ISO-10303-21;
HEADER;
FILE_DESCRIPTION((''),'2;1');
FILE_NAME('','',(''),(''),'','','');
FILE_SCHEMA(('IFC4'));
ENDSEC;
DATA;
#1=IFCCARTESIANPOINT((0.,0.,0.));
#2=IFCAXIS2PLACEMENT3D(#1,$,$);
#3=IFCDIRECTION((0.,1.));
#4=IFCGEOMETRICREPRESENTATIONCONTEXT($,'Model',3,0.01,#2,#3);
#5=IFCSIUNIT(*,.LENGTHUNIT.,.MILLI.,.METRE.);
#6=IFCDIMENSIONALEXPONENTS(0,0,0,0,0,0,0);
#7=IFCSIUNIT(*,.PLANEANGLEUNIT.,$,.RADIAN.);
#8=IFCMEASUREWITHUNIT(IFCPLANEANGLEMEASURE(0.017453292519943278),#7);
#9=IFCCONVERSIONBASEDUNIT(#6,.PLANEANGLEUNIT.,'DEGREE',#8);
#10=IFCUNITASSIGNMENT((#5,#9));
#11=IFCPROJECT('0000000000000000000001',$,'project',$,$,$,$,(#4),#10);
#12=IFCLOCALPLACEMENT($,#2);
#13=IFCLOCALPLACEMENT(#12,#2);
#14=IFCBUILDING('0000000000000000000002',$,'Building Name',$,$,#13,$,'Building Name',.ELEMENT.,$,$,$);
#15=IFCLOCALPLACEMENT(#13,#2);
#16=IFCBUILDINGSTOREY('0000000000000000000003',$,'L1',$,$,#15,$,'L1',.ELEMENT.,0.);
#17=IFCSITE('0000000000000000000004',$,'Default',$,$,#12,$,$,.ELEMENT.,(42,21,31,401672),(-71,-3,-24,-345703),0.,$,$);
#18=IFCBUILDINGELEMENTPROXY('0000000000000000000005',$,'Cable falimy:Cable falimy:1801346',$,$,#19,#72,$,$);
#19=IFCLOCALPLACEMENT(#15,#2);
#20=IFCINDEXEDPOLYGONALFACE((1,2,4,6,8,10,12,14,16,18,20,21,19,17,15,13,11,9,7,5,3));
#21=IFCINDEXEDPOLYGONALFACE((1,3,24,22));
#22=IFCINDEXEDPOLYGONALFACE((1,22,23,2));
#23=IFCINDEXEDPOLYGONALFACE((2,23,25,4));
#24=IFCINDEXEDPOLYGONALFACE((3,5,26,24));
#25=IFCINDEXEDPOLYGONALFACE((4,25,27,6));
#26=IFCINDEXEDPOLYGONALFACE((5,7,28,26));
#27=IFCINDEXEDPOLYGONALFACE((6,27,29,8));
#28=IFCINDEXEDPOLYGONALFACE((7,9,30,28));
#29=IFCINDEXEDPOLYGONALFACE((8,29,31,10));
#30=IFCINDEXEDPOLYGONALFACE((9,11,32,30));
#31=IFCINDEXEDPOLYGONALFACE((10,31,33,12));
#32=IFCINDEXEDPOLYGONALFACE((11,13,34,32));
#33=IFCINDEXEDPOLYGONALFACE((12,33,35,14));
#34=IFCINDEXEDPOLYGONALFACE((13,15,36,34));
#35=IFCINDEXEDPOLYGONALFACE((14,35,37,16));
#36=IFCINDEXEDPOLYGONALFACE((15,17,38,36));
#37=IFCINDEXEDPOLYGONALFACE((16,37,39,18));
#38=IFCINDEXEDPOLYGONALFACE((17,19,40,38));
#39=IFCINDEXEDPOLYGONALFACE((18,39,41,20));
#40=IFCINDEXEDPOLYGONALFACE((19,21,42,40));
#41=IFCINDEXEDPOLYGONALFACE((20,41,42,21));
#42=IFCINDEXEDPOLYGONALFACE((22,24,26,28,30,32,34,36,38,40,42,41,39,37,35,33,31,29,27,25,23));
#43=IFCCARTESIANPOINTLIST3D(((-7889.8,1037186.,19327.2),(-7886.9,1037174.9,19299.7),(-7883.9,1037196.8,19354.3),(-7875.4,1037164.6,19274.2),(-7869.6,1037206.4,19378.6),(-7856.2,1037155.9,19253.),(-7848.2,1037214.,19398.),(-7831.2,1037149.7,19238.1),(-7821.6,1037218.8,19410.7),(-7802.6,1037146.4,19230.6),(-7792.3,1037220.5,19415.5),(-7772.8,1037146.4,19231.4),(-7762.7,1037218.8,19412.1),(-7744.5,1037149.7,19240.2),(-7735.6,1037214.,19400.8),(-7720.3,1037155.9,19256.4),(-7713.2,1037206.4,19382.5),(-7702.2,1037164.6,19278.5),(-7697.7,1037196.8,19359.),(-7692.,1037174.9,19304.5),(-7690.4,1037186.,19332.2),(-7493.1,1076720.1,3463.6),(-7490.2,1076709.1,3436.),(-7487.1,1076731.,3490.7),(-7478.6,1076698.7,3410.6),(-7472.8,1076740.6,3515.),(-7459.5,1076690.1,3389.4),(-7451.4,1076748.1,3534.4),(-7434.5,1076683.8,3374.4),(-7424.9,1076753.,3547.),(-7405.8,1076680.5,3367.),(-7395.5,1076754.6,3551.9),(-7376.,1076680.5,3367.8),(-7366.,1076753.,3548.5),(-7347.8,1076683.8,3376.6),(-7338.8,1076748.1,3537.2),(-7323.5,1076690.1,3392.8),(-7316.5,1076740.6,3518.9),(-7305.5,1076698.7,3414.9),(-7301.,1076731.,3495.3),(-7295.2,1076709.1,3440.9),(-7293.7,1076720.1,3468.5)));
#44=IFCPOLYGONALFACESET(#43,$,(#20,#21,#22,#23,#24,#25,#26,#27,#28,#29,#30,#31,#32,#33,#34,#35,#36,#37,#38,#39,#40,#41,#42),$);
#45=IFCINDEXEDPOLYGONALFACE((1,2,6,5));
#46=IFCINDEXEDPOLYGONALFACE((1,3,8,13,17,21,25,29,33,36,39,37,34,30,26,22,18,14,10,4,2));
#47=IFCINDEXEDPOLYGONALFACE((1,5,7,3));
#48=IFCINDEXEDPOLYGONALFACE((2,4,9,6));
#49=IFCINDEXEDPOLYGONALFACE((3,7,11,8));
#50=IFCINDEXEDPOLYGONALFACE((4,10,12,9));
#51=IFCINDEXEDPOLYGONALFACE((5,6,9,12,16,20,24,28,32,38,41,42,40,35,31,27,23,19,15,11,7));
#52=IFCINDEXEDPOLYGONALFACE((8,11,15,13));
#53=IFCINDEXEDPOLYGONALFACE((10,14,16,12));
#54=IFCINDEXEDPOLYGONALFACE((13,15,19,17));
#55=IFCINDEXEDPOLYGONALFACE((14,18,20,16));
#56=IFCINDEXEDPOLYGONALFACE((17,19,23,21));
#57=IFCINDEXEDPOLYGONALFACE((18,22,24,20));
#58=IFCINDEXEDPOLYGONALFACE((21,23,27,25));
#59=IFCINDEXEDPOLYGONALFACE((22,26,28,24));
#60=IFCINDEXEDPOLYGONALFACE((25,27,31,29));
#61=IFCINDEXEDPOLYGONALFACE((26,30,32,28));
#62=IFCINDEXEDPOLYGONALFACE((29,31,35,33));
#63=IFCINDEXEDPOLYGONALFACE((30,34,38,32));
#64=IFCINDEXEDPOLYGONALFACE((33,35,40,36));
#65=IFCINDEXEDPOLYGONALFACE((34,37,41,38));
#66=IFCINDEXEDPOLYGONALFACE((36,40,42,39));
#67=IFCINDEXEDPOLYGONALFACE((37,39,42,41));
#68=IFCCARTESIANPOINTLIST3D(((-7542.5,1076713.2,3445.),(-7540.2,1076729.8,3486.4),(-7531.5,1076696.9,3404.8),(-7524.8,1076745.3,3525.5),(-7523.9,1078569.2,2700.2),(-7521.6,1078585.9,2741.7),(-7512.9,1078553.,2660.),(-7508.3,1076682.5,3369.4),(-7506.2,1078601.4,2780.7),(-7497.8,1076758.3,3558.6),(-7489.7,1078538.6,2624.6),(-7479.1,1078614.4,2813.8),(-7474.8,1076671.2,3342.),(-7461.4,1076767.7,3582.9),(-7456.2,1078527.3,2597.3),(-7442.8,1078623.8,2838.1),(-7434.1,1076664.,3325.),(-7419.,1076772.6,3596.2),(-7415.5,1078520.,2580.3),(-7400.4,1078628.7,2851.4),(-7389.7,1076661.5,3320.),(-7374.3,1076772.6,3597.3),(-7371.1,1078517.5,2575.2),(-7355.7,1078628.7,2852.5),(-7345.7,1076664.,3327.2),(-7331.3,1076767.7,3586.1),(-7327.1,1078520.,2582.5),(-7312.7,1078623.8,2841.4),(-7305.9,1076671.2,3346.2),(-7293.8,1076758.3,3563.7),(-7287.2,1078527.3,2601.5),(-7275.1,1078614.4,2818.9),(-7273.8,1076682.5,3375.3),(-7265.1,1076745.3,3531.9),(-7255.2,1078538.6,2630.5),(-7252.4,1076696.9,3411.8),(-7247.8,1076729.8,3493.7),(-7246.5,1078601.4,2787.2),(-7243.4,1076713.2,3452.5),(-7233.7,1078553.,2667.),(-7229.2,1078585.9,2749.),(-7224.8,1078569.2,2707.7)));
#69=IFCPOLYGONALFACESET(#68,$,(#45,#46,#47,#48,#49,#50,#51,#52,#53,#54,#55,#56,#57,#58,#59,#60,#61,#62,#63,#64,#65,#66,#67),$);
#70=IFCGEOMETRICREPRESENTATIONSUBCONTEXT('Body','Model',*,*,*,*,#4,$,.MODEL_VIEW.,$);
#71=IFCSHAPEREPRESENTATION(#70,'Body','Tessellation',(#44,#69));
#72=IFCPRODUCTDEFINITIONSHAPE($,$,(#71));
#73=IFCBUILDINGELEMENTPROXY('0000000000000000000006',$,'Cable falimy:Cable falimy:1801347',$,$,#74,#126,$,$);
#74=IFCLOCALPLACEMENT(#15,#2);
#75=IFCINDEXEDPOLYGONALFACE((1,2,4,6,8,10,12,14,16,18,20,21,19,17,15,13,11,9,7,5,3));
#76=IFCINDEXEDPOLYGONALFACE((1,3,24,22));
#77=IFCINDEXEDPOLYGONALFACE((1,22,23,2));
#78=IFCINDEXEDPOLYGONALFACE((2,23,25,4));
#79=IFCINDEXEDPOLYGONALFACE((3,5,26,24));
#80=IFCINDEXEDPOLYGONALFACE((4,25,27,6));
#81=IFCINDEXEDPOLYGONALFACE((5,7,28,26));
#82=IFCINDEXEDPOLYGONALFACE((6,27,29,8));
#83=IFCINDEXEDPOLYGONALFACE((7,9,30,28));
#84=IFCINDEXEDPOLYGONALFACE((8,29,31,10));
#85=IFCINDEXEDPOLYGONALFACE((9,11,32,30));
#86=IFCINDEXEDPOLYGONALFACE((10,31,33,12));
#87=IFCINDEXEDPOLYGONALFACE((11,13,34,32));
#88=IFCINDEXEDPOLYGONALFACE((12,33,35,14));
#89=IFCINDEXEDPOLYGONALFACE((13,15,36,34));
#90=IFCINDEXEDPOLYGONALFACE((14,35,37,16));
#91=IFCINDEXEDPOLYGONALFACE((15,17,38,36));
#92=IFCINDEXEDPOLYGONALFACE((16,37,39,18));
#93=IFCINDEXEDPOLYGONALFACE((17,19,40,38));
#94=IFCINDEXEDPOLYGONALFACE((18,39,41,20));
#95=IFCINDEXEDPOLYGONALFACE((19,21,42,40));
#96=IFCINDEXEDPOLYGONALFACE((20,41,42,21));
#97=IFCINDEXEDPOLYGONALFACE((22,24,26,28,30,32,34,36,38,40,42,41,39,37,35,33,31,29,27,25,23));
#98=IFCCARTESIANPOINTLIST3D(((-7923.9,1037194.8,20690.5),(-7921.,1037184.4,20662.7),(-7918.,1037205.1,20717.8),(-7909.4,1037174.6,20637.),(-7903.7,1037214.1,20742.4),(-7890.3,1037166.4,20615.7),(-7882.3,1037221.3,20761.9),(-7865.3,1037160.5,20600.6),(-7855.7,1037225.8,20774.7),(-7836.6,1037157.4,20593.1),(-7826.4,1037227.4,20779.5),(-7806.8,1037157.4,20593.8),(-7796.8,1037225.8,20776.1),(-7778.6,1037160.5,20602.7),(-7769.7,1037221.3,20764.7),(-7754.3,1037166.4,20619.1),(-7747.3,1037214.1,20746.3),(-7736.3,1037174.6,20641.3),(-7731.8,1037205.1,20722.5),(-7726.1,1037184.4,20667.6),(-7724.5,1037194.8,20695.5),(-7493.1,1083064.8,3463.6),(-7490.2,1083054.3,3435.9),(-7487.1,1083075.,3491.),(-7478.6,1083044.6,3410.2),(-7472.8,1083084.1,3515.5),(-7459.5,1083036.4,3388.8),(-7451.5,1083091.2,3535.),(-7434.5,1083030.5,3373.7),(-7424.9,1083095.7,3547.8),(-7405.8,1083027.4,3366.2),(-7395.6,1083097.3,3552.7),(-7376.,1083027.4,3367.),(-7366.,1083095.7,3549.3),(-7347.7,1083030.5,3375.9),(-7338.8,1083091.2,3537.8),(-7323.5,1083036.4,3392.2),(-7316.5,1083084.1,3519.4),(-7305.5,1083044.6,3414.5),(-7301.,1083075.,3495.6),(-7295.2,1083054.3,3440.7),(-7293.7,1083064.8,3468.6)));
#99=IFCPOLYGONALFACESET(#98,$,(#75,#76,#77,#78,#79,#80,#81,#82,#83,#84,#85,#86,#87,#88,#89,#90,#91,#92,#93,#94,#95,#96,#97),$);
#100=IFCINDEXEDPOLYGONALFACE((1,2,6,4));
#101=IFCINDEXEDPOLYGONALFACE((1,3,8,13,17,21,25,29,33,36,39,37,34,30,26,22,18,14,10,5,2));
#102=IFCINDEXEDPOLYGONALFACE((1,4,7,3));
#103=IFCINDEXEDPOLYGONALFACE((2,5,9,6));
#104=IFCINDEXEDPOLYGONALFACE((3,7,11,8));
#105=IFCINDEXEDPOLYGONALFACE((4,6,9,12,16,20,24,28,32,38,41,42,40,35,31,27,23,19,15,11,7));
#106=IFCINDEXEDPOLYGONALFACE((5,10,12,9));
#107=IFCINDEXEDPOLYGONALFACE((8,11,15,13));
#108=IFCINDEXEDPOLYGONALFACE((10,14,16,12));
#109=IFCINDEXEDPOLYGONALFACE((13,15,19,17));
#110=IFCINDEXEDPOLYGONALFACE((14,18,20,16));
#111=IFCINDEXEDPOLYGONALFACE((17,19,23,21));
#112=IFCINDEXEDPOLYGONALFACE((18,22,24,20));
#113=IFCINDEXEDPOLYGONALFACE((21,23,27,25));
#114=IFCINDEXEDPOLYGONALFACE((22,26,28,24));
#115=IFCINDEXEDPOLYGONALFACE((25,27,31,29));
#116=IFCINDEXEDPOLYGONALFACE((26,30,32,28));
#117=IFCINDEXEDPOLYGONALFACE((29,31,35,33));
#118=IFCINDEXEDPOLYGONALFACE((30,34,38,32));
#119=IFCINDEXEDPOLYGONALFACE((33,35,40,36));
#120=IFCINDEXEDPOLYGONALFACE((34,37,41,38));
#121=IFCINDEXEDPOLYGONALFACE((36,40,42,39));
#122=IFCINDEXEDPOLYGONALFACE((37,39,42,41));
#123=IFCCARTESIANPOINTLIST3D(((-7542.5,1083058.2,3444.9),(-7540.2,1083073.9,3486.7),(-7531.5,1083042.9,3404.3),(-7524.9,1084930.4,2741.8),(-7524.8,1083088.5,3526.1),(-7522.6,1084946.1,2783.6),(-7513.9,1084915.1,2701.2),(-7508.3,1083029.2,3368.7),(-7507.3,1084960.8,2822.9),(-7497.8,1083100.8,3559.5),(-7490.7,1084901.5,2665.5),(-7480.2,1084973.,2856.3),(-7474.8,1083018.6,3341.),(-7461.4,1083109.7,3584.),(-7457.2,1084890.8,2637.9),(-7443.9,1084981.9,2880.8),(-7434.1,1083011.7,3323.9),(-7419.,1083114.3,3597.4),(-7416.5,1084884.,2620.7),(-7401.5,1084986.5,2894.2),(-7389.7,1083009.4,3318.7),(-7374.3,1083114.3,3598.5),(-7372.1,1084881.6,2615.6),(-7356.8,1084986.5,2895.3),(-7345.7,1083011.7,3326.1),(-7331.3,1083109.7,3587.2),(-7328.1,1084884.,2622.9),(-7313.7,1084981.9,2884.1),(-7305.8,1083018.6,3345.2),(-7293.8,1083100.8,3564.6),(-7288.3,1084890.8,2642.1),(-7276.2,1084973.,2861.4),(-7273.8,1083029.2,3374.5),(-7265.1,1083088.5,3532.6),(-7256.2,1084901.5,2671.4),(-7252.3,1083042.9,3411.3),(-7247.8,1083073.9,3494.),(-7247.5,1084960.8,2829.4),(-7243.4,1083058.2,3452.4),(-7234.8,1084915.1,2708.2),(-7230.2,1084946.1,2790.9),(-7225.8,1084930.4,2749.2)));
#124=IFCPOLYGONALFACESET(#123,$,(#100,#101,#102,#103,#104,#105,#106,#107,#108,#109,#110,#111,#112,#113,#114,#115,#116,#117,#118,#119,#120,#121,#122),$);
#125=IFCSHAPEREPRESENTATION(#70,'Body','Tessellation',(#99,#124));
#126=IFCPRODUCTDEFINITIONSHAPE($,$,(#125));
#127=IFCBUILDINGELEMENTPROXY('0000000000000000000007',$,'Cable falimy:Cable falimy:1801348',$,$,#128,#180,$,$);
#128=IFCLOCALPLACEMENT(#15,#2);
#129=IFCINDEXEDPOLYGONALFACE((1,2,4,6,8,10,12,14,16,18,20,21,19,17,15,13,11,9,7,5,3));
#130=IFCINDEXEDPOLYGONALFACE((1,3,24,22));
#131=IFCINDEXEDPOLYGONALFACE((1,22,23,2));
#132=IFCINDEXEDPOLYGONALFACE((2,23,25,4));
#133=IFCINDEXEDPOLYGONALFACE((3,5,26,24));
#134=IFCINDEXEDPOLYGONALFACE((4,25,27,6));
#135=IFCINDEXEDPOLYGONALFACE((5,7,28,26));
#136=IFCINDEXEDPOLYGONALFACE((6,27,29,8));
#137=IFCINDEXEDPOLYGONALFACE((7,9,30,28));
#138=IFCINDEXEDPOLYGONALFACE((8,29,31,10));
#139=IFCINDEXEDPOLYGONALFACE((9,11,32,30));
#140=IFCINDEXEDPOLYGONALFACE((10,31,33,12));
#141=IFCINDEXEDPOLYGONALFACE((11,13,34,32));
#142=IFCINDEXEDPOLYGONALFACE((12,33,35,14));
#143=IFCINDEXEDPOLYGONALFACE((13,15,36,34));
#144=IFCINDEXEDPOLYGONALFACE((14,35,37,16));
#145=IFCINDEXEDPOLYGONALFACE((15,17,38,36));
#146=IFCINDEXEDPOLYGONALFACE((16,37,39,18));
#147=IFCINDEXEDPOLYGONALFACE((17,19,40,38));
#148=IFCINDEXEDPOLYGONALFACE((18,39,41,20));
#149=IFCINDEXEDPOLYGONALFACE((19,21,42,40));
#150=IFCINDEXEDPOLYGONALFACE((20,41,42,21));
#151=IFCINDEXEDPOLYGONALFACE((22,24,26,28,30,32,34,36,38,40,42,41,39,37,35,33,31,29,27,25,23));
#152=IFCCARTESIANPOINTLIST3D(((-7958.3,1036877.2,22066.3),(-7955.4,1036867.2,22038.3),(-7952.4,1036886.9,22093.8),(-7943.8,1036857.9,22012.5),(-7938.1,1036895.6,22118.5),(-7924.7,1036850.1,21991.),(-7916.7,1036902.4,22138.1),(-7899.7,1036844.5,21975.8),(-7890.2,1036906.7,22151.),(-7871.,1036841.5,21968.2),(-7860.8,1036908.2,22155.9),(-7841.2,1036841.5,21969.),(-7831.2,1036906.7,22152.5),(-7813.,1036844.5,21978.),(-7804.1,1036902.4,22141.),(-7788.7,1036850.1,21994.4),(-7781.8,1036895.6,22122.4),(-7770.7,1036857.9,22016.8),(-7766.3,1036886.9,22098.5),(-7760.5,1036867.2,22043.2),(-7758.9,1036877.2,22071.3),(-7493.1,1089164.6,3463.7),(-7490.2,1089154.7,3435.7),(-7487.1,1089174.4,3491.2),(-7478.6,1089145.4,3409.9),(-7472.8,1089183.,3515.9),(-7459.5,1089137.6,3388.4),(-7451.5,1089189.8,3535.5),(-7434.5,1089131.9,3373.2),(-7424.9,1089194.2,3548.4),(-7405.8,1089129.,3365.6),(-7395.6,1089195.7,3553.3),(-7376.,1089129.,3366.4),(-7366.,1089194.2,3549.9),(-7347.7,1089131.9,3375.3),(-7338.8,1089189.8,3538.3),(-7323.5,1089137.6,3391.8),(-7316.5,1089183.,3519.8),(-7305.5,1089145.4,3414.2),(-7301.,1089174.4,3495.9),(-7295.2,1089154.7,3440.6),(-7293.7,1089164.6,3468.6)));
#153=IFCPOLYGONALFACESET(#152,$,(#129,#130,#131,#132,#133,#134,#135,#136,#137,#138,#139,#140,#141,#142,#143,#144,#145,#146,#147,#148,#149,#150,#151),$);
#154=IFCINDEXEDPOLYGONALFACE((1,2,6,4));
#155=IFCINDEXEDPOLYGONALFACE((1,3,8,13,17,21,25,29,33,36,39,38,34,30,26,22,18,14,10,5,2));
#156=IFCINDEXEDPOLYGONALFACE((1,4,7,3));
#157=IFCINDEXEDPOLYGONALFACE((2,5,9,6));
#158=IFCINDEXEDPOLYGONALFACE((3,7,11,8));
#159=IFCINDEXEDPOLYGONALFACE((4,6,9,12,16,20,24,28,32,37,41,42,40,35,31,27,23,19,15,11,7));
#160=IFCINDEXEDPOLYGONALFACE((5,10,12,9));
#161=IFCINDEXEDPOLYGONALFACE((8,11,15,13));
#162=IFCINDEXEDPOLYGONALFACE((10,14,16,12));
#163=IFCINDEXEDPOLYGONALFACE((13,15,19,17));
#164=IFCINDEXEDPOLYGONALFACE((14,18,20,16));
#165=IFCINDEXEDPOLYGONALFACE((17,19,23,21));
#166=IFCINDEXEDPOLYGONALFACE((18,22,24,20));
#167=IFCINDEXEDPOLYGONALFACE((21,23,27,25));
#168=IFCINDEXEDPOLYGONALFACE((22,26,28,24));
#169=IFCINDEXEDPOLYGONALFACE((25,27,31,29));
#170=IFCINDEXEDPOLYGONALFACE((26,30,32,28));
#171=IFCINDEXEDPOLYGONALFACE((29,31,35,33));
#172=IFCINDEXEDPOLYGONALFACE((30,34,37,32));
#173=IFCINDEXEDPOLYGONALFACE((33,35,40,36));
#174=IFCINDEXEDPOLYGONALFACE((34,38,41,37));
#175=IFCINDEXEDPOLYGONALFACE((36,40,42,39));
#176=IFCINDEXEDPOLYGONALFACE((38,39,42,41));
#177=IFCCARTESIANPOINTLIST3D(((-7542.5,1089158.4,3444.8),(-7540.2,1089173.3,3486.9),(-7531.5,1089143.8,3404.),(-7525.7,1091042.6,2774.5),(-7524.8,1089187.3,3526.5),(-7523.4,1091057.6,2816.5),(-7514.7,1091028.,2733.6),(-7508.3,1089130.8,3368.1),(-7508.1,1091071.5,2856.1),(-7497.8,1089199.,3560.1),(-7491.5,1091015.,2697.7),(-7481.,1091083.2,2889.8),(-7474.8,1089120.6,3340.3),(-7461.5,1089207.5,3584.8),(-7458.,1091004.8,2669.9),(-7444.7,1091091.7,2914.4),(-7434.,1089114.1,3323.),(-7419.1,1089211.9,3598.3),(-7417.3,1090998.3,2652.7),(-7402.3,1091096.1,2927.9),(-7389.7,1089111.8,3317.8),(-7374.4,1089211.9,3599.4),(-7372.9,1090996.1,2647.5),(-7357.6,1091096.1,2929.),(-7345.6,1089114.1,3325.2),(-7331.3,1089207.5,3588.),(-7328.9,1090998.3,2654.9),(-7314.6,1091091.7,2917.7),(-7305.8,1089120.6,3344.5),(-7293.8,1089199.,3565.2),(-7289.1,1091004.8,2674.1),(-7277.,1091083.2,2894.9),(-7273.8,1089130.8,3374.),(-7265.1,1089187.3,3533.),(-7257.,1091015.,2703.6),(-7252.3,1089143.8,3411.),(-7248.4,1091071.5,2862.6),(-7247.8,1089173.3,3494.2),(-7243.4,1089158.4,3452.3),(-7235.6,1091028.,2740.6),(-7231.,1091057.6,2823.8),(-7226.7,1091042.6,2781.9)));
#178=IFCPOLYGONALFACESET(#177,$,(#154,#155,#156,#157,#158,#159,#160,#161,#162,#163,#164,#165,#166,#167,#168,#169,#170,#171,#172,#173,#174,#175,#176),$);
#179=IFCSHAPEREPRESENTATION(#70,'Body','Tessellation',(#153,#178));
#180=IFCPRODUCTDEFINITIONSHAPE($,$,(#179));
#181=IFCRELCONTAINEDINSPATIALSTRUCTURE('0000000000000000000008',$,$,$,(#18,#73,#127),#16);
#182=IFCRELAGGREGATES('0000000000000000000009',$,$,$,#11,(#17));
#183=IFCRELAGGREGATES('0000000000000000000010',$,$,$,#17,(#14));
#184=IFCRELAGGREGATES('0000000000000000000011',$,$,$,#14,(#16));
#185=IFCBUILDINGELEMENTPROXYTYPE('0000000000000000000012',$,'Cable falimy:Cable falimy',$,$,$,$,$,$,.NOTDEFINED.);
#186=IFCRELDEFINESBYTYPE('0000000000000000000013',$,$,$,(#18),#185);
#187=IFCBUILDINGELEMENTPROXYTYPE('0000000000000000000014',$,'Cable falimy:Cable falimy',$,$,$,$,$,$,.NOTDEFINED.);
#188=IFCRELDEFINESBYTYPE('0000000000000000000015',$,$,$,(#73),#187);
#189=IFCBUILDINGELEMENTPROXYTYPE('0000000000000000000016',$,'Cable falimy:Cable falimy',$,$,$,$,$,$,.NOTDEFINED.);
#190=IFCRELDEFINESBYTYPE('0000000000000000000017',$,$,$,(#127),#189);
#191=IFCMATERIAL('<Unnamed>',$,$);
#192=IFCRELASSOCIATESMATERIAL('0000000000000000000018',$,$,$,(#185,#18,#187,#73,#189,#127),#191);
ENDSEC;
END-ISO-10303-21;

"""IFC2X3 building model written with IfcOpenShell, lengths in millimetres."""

from ifc_helpers import new_model, entity, si_unit, converted_unit, direction, frame, frame_2d, origin, place, context, subcontext, project, spatial, circle, extrude, source, transform, mapped, material, type_object, type_shapes, element, save


model = new_model("IFC2X3")

# Units and contexts
model_context = context("Model", 3, precision=0.01, world=origin(), true_north=direction((0.0, 1.0)))
body_context = subcontext(model_context, "Body", "Model", "MODEL_VIEW")
ifc_project = project(units=[si_unit("LENGTHUNIT", "METRE", prefix="MILLI"), converted_unit("PLANEANGLEUNIT", "DEGREE", entity("IfcPlaneAngleMeasure", 0.017453292519943278), si_unit("PLANEANGLEUNIT", "RADIAN"), dimensions=[0, 0, 0, 0, 0, 0, 0])], contexts=[model_context])

# Site, building, storey
site_placement = place(None, origin())
site = spatial("IfcSite", under=ifc_project, at=site_placement, Name="Default", CompositionType="ELEMENT", RefLatitude=(42, 21, 31, 401672), RefLongitude=(-71, -3, -24, -345703), RefElevation=0.0)
building_placement = place(site_placement, origin())
building = spatial("IfcBuilding", under=site, at=building_placement, Name="Building Name", LongName="Building Name", CompositionType="ELEMENT")
storey_placement = place(building_placement, origin())
storey = spatial("IfcBuildingStorey", under=building, at=storey_placement, Name="L1", LongName="L1", CompositionType="ELEMENT", Elevation=0.0)

# Shared definitions
ifc_material = material(Name="<Unnamed>")

# Building element proxies
building_element_proxy_type_1 = type_object("IfcBuildingElementProxyType", Name="Cable falimy:Cable falimy", PredefinedType="NOTDEFINED", material=ifc_material)
shared_shape_1 = source(origin(), body_context, "Body", "SweptSolid", [
    extrude(circle(Radius=100.0, at=frame_2d((0.0, 0.0), x_axis=(1.0, 0.0))), frame((0.0, 0.0, 0.0), z_axis=(0.928031, 0.0, 0.372502), x_axis=(-0.372502, 0.0, 0.928031)), (0.0, 0.0, 1.0), 42600.0),
    extrude(circle(Radius=150.0, at=frame_2d((0.0, 0.0), x_axis=(1.0, 0.0))), frame((-1856.1, 0.0, -745.0), z_axis=(0.928031, 0.0, 0.372502), x_axis=(0.372502, 0.0, -0.928031)), (0.0, 0.0, 1.0), 2000.0),
])
type_shapes(building_element_proxy_type_1, [shared_shape_1])
proxy_1_placement = place(storey_placement, frame((-7393.2, 1076717.4, 3459.1), z_axis=(-0.025001, 0.0, 0.999687), x_axis=(0.0, -1.0, 0.0)))
element("IfcBuildingElementProxy", 1, at=proxy_1_placement, inside=storey, type_object=building_element_proxy_type_1, material=ifc_material, Name="Cable falimy:Cable falimy:1801346", context=body_context, shape_type="MappedRepresentation", body=[
    mapped(shared_shape_1, transform((0.0, 0.0, 0.0), scale=1.0)),
])
building_element_proxy_type_2 = type_object("IfcBuildingElementProxyType", Name="Cable falimy:Cable falimy", PredefinedType="NOTDEFINED", material=ifc_material)
shared_shape_2 = source(origin(), body_context, "Body", "SweptSolid", [
    extrude(circle(Radius=100.0, at=frame_2d((0.0, 0.0), x_axis=(1.0, 0.0))), frame((0.0, 0.0, 0.0), z_axis=(0.936121, 0.0, 0.351678), x_axis=(-0.351678, 0.0, 0.936121)), (0.0, 0.0, 1.0), 49000.0),
    extrude(circle(Radius=150.0, at=frame_2d((0.0, 0.0), x_axis=(1.0, 0.0))), frame((-1872.2, 0.0, -703.4), z_axis=(0.936121, 0.0, 0.351678), x_axis=(0.351678, 0.0, -0.936121)), (0.0, 0.0, 1.0), 2000.0),
])
type_shapes(building_element_proxy_type_2, [shared_shape_2])
proxy_2_placement = place(storey_placement, frame((-7393.2, 1083062.1, 3459.1), z_axis=(-0.025001, 0.0, 0.999687), x_axis=(0.0, -1.0, 0.0)))
element("IfcBuildingElementProxy", 2, at=proxy_2_placement, inside=storey, type_object=building_element_proxy_type_2, material=ifc_material, Name="Cable falimy:Cable falimy:1801347", context=body_context, shape_type="MappedRepresentation", body=[
    mapped(shared_shape_2, transform((0.0, 0.0, 0.0), scale=1.0)),
])
building_element_proxy_type_3 = type_object("IfcBuildingElementProxyType", Name="Cable falimy:Cable falimy", PredefinedType="NOTDEFINED", material=ifc_material)
shared_shape_3 = source(origin(), body_context, "Body", "SweptSolid", [
    extrude(circle(Radius=100.0, at=frame_2d((0.0, 0.0), x_axis=(1.0, 0.0))), frame((0.0, 0.0, 0.0), z_axis=(0.942116, 0.0, 0.335287), x_axis=(-0.335287, 0.0, 0.942116)), (0.0, 0.0, 1.0), 55500.0),
    extrude(circle(Radius=150.0, at=frame_2d((0.0, 0.0), x_axis=(1.0, 0.0))), frame((-1884.2, 0.0, -670.6), z_axis=(0.942116, 0.0, 0.335287), x_axis=(0.335287, 0.0, -0.942116)), (0.0, 0.0, 1.0), 2000.0),
])
type_shapes(building_element_proxy_type_3, [shared_shape_3])
proxy_3_placement = place(storey_placement, frame((-7393.2, 1089162.1, 3459.1), z_axis=(-0.025001, 0.0, 0.999687), x_axis=(0.0, -1.0, 0.0)))
element("IfcBuildingElementProxy", 3, at=proxy_3_placement, inside=storey, type_object=building_element_proxy_type_3, material=ifc_material, Name="Cable falimy:Cable falimy:1801348", context=body_context, shape_type="MappedRepresentation", body=[
    mapped(shared_shape_3, transform((0.0, 0.0, 0.0), scale=1.0)),
])

save(model, "model.ifc")
